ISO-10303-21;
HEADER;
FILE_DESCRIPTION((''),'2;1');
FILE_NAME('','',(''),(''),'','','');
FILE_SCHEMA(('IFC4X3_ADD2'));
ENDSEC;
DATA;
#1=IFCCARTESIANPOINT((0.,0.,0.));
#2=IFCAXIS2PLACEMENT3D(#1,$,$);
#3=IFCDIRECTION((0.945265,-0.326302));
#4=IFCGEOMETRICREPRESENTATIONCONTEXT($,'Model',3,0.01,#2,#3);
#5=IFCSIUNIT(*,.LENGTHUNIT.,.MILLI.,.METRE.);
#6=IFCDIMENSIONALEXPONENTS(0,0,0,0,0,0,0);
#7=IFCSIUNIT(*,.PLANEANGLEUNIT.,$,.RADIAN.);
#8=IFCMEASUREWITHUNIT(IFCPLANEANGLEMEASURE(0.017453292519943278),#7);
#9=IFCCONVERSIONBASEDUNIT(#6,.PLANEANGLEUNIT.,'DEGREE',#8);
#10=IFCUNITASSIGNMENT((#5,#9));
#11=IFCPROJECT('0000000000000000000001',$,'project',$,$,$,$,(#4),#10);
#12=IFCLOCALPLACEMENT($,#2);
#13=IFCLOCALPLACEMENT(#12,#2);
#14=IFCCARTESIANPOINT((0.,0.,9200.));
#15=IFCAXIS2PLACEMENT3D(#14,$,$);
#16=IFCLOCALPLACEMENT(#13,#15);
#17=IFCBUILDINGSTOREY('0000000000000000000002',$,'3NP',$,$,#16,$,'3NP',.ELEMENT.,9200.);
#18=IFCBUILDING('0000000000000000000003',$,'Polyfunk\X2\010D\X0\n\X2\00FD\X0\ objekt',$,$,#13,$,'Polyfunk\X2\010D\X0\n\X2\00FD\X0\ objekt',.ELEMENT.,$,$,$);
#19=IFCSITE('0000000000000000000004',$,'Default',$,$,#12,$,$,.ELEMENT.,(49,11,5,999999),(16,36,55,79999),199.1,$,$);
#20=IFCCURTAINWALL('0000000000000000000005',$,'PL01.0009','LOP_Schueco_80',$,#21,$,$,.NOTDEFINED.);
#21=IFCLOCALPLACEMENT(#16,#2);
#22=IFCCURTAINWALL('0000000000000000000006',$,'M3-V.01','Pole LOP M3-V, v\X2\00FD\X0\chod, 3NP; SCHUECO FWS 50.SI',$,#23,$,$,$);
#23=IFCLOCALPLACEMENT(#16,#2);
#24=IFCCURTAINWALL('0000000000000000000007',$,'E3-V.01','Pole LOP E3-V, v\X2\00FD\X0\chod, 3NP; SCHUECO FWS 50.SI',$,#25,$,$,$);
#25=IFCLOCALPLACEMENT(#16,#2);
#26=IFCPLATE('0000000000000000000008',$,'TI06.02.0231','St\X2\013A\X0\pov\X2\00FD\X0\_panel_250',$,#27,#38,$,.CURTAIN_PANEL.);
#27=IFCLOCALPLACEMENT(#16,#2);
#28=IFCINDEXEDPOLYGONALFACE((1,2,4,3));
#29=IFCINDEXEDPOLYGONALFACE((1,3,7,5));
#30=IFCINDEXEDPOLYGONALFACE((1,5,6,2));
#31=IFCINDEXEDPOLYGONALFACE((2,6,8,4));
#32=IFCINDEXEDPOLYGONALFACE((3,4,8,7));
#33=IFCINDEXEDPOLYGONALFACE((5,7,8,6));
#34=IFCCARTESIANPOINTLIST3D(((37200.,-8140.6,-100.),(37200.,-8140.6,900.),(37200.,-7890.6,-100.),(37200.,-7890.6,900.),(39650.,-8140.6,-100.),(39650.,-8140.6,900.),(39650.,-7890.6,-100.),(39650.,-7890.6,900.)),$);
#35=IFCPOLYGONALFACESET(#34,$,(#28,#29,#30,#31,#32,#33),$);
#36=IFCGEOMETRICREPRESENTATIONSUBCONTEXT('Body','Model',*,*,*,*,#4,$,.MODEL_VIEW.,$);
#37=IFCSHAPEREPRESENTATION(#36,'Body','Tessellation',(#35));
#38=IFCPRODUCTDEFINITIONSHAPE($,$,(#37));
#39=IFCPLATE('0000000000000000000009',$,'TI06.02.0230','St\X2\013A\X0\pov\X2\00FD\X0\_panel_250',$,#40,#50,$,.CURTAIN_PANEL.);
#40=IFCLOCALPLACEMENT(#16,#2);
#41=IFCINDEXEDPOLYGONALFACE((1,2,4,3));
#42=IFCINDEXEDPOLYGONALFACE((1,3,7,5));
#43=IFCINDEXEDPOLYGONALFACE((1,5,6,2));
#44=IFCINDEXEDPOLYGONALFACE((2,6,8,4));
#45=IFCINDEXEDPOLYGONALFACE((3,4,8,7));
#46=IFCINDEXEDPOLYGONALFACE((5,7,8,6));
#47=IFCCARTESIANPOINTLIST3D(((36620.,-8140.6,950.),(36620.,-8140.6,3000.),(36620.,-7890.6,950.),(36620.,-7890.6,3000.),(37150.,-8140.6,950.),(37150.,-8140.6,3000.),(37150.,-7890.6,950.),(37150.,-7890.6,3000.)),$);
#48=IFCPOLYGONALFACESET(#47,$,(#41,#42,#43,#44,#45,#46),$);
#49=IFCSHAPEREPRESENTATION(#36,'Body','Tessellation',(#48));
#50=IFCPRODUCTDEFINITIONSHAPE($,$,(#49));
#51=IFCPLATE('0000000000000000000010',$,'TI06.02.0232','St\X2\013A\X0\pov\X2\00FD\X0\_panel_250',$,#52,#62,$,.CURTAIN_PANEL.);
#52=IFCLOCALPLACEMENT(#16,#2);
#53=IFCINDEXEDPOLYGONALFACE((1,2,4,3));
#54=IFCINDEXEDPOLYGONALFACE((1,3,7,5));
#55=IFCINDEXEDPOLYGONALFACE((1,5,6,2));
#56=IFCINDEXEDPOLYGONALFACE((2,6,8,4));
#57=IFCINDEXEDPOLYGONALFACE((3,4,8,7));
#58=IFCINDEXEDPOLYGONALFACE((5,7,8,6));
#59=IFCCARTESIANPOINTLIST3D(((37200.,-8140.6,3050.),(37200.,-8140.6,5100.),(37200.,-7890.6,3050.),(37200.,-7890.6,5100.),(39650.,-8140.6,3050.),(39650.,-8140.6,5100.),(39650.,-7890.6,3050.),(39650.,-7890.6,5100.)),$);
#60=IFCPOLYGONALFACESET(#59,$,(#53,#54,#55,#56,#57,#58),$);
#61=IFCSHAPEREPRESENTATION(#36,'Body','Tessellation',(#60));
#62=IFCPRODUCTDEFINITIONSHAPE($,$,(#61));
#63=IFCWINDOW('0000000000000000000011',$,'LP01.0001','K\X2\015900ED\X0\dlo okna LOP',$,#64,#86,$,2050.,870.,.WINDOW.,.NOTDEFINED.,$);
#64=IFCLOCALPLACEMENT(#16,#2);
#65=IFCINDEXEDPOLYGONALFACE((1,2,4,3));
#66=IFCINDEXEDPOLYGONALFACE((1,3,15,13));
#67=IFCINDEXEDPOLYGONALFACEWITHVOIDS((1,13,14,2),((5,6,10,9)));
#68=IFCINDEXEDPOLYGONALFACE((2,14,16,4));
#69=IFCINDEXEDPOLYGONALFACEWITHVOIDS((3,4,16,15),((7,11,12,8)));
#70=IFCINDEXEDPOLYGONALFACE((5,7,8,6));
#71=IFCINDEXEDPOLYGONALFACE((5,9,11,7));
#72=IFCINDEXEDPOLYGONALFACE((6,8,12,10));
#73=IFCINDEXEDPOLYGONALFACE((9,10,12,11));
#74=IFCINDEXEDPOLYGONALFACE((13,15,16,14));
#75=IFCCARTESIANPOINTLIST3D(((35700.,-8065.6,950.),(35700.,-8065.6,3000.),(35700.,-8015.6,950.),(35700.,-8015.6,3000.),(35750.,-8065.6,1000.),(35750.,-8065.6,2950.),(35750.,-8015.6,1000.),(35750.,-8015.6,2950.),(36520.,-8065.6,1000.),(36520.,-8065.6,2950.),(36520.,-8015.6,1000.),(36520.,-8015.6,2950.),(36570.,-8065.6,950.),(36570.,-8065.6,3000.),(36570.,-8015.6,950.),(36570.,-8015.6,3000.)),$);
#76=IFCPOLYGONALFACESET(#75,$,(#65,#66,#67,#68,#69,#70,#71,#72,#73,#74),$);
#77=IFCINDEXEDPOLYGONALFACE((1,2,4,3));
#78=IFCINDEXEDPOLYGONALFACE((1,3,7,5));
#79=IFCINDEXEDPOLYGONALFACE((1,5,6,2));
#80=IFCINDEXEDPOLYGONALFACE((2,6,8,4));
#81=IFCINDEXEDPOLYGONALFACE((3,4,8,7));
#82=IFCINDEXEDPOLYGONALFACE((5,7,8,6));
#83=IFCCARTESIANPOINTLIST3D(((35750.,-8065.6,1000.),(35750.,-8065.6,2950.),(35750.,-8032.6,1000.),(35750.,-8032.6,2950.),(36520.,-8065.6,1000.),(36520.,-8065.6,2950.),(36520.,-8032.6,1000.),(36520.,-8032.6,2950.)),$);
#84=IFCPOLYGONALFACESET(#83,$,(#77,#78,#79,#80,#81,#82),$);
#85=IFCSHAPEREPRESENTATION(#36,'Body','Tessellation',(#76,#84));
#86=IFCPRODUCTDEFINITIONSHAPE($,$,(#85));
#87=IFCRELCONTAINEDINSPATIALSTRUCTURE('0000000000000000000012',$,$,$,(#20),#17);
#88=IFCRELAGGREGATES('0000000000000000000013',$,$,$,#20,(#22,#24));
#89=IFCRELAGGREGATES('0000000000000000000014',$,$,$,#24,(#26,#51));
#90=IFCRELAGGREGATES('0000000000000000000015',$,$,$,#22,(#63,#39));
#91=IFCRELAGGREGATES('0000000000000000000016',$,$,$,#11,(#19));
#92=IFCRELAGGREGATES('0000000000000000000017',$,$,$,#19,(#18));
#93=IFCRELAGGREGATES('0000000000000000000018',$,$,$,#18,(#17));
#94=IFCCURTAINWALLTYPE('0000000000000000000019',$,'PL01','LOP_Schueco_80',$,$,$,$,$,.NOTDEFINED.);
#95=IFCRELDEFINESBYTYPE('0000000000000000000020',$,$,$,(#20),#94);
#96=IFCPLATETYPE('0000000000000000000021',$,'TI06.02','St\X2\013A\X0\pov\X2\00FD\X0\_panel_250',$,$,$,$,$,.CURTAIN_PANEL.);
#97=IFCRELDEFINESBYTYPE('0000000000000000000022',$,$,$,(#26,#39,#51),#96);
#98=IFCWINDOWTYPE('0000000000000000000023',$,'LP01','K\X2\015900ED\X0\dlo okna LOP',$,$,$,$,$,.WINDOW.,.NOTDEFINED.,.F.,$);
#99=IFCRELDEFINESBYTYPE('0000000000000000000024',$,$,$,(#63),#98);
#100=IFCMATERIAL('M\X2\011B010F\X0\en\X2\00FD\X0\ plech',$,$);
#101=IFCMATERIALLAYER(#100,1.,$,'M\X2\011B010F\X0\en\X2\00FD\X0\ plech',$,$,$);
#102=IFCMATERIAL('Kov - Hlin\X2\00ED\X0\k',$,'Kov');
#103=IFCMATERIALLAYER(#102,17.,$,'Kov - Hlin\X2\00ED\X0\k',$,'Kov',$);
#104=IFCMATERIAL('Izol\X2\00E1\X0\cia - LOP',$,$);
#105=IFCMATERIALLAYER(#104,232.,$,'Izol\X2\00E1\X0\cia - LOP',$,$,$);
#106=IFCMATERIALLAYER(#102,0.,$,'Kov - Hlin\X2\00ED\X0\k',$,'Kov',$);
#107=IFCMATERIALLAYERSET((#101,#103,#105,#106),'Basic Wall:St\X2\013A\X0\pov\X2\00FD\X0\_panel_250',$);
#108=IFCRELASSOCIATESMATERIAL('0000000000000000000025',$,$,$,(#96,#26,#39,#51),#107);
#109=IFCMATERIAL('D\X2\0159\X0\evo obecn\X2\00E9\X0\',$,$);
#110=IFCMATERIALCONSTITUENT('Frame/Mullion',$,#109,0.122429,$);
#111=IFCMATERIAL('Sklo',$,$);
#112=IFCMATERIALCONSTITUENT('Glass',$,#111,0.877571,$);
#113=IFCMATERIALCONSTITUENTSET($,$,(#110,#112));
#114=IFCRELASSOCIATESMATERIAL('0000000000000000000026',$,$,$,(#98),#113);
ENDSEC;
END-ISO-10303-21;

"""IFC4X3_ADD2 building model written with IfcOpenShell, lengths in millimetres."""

from ifc_helpers import new_model, entity, si_unit, converted_unit, direction, frame, frame_2d, origin, place, context, subcontext, project, spatial, polyline, rectangle, outline, extrude, source, transform, mapped, material, layer, layer_set, layer_usage, constituent, constituent_set, type_object, type_shapes, element, aggregate, save


model = new_model("IFC4X3_ADD2")

# Units and contexts
model_context = context("Model", 3, precision=0.01, world=origin(), true_north=direction((0.945265, -0.326302)))
body_context = subcontext(model_context, "Body", "Model", "MODEL_VIEW")
ifc_project = project(units=[si_unit("LENGTHUNIT", "METRE", prefix="MILLI"), converted_unit("PLANEANGLEUNIT", "DEGREE", entity("IfcPlaneAngleMeasure", 0.017453292519943278), si_unit("PLANEANGLEUNIT", "RADIAN"), dimensions=[0, 0, 0, 0, 0, 0, 0])], contexts=[model_context])

# Site, building, storey
site_placement = place(None, origin())
site = spatial("IfcSite", under=ifc_project, at=site_placement, Name="Default", CompositionType="ELEMENT", RefLatitude=(49, 11, 5, 999999), RefLongitude=(16, 36, 55, 79999), RefElevation=199.1)
building_placement = place(site_placement, origin())
building = spatial("IfcBuilding", under=site, at=building_placement, Name="Polyfunkčný objekt", LongName="Polyfunkčný objekt", CompositionType="ELEMENT")
storey_placement = place(building_placement, frame((0.0, 0.0, 9200.0)))
storey = spatial("IfcBuildingStorey", under=building, at=storey_placement, Name="3NP", LongName="3NP", CompositionType="ELEMENT", Elevation=9200.0)

# Curtain walls, plates, window
curtain_wall_type = type_object("IfcCurtainWallType", Name="PL01", Description="LOP_Schueco_80", PredefinedType="NOTDEFINED")
curtain_wall_1_placement = place(storey_placement, frame((0.0, 0.0, -9200.0)))
curtain_wall_1 = element("IfcCurtainWall", 1, at=curtain_wall_1_placement, inside=storey, type_object=curtain_wall_type, Name="PL01.0009", Description="LOP_Schueco_80", PredefinedType="NOTDEFINED")
curtain_wall_2 = element("IfcCurtainWall", 2, Name="M3-V.01", Description="Pole LOP M3-V, východ, 3NP; SCHUECO FWS 50.SI")
curtain_wall_3 = element("IfcCurtainWall", 3, Name="E3-V.01", Description="Pole LOP E3-V, východ, 3NP; SCHUECO FWS 50.SI")
aggregate(curtain_wall_1, [curtain_wall_2, curtain_wall_3])
ifc_material_1 = material(Name="Měďený plech")
ifc_layer_1 = layer(ifc_material_1, 1.0, Name="Měďený plech")
ifc_material_2 = material(Name="Kov - Hliník", Category="Kov")
ifc_layer_2 = layer(ifc_material_2, 17.0, Name="Kov - Hliník", Category="Kov")
ifc_material_3 = material(Name="Izolácia - LOP")
ifc_layer_3 = layer(ifc_material_3, 232.0, Name="Izolácia - LOP")
ifc_layer_4 = layer(ifc_material_2, 0.0, Name="Kov - Hliník", Category="Kov")
ifc_layer_set = layer_set([ifc_layer_1, ifc_layer_2, ifc_layer_3, ifc_layer_4], Name="Basic Wall:Stĺpový_panel_250")
ifc_layer_usage_1 = layer_usage(ifc_layer_set, "AXIS2", "POSITIVE", -125.0)
plate_type = type_object("IfcPlateType", Name="TI06.02", Description="Stĺpový_panel_250", PredefinedType="CURTAIN_PANEL", material=ifc_layer_set)
plate_1_placement = place(storey_placement, frame((37200.0, -8015.6, -100.0)))
plate_1 = element("IfcPlate", 4, at=plate_1_placement, type_object=plate_type, material=ifc_layer_usage_1, Name="TI06.02.0231", Description="Stĺpový_panel_250", PredefinedType="CURTAIN_PANEL", context=body_context, shape_type="SweptSolid", body=[
    extrude(rectangle(XDim=250.0, YDim=2450.0, at=frame_2d((0.0, 0.0), x_axis=(1.0, 0.0))), frame((1225.0, 0.0, 0.0), z_axis=(0.0, 0.0, 1.0), x_axis=(0.0, 1.0, 0.0)), (0.0, 0.0, 1.0), 1000.0),
])
ifc_layer_usage_2 = layer_usage(ifc_layer_set, "AXIS2", "POSITIVE", -125.0)
plate_2_placement = place(storey_placement, frame((36620.0, -8015.6, 950.0)))
plate_2 = element("IfcPlate", 5, at=plate_2_placement, type_object=plate_type, material=ifc_layer_usage_2, Name="TI06.02.0230", Description="Stĺpový_panel_250", PredefinedType="CURTAIN_PANEL", context=body_context, shape_type="SweptSolid", body=[
    extrude(rectangle(XDim=250.0, YDim=530.0, at=frame_2d((0.0, 0.0), x_axis=(1.0, 0.0))), frame((265.0, 0.0, 0.0), z_axis=(0.0, 0.0, 1.0), x_axis=(0.0, 1.0, 0.0)), (0.0, 0.0, 1.0), 2050.0),
])
ifc_layer_usage_3 = layer_usage(ifc_layer_set, "AXIS2", "POSITIVE", -125.0)
plate_3_placement = place(storey_placement, frame((37200.0, -8015.6, 3050.0)))
plate_3 = element("IfcPlate", 6, at=plate_3_placement, type_object=plate_type, material=ifc_layer_usage_3, Name="TI06.02.0232", Description="Stĺpový_panel_250", PredefinedType="CURTAIN_PANEL", context=body_context, shape_type="SweptSolid", body=[
    extrude(rectangle(XDim=250.0, YDim=2450.0, at=frame_2d((0.0, 0.0), x_axis=(1.0, 0.0))), frame((1225.0, 0.0, 0.0), z_axis=(0.0, 0.0, 1.0), x_axis=(0.0, 1.0, 0.0)), (0.0, 0.0, 1.0), 2050.0),
])
aggregate(curtain_wall_3, [plate_1, plate_3])
ifc_material_4 = material(Name="Dřevo obecné")
ifc_constituent_1 = constituent(ifc_material_4, Name="Frame/Mullion", fraction=0.122429)
ifc_material_5 = material(Name="Sklo")
ifc_constituent_2 = constituent(ifc_material_5, Name="Glass", fraction=0.877571)
ifc_constituent_set = constituent_set(constituents=[ifc_constituent_1, ifc_constituent_2])
window_type = type_object("IfcWindowType", Name="LP01", Description="Křídlo okna LOP", ParameterTakesPrecedence=False, PartitioningType="NOTDEFINED", PredefinedType="WINDOW", material=ifc_constituent_set)
shared_shape_1 = source(origin(), body_context, "Body", "SweptSolid", [
    extrude(outline(polyline([(-1025.0, -435.0), (1025.0, -435.0), (1025.0, 435.0), (-1025.0, 435.0), (-1025.0, -435.0)]), holes=[polyline([(-975.0, -385.0), (-975.0, 385.0), (975.0, 385.0), (975.0, -385.0), (-975.0, -385.0)])]), frame((0.0, 50.0, 1025.0), z_axis=(0.0, -1.0, 0.0), x_axis=(0.0, 0.0, -1.0)), (0.0, 0.0, 1.0), 50.0),
    extrude(rectangle(XDim=770.0, YDim=33.0, at=frame_2d((0.0, 0.0), x_axis=(1.0, 0.0))), frame((0.0, 33.5, 50.0), z_axis=(0.0, 0.0, 1.0), x_axis=(-1.0, 0.0, 0.0)), (0.0, 0.0, 1.0), 1950.0),
])
type_shapes(window_type, [shared_shape_1])
window_placement = place(curtain_wall_1_placement, frame((36135.0, -8015.6, 10150.0), z_axis=(0.0, 0.0, 1.0), x_axis=(-1.0, 0.0, 0.0)))
window = element("IfcWindow", 7, at=window_placement, type_object=window_type, Name="LP01.0001", Description="Křídlo okna LOP", OverallHeight=2050.0, OverallWidth=870.0, PartitioningType="NOTDEFINED", PredefinedType="WINDOW", context=body_context, shape_type="MappedRepresentation", body=[
    mapped(shared_shape_1, transform((0.0, 0.0, 0.0), scale=1.0)),
])
aggregate(curtain_wall_2, [window, plate_2])

save(model, "model.ifc")
